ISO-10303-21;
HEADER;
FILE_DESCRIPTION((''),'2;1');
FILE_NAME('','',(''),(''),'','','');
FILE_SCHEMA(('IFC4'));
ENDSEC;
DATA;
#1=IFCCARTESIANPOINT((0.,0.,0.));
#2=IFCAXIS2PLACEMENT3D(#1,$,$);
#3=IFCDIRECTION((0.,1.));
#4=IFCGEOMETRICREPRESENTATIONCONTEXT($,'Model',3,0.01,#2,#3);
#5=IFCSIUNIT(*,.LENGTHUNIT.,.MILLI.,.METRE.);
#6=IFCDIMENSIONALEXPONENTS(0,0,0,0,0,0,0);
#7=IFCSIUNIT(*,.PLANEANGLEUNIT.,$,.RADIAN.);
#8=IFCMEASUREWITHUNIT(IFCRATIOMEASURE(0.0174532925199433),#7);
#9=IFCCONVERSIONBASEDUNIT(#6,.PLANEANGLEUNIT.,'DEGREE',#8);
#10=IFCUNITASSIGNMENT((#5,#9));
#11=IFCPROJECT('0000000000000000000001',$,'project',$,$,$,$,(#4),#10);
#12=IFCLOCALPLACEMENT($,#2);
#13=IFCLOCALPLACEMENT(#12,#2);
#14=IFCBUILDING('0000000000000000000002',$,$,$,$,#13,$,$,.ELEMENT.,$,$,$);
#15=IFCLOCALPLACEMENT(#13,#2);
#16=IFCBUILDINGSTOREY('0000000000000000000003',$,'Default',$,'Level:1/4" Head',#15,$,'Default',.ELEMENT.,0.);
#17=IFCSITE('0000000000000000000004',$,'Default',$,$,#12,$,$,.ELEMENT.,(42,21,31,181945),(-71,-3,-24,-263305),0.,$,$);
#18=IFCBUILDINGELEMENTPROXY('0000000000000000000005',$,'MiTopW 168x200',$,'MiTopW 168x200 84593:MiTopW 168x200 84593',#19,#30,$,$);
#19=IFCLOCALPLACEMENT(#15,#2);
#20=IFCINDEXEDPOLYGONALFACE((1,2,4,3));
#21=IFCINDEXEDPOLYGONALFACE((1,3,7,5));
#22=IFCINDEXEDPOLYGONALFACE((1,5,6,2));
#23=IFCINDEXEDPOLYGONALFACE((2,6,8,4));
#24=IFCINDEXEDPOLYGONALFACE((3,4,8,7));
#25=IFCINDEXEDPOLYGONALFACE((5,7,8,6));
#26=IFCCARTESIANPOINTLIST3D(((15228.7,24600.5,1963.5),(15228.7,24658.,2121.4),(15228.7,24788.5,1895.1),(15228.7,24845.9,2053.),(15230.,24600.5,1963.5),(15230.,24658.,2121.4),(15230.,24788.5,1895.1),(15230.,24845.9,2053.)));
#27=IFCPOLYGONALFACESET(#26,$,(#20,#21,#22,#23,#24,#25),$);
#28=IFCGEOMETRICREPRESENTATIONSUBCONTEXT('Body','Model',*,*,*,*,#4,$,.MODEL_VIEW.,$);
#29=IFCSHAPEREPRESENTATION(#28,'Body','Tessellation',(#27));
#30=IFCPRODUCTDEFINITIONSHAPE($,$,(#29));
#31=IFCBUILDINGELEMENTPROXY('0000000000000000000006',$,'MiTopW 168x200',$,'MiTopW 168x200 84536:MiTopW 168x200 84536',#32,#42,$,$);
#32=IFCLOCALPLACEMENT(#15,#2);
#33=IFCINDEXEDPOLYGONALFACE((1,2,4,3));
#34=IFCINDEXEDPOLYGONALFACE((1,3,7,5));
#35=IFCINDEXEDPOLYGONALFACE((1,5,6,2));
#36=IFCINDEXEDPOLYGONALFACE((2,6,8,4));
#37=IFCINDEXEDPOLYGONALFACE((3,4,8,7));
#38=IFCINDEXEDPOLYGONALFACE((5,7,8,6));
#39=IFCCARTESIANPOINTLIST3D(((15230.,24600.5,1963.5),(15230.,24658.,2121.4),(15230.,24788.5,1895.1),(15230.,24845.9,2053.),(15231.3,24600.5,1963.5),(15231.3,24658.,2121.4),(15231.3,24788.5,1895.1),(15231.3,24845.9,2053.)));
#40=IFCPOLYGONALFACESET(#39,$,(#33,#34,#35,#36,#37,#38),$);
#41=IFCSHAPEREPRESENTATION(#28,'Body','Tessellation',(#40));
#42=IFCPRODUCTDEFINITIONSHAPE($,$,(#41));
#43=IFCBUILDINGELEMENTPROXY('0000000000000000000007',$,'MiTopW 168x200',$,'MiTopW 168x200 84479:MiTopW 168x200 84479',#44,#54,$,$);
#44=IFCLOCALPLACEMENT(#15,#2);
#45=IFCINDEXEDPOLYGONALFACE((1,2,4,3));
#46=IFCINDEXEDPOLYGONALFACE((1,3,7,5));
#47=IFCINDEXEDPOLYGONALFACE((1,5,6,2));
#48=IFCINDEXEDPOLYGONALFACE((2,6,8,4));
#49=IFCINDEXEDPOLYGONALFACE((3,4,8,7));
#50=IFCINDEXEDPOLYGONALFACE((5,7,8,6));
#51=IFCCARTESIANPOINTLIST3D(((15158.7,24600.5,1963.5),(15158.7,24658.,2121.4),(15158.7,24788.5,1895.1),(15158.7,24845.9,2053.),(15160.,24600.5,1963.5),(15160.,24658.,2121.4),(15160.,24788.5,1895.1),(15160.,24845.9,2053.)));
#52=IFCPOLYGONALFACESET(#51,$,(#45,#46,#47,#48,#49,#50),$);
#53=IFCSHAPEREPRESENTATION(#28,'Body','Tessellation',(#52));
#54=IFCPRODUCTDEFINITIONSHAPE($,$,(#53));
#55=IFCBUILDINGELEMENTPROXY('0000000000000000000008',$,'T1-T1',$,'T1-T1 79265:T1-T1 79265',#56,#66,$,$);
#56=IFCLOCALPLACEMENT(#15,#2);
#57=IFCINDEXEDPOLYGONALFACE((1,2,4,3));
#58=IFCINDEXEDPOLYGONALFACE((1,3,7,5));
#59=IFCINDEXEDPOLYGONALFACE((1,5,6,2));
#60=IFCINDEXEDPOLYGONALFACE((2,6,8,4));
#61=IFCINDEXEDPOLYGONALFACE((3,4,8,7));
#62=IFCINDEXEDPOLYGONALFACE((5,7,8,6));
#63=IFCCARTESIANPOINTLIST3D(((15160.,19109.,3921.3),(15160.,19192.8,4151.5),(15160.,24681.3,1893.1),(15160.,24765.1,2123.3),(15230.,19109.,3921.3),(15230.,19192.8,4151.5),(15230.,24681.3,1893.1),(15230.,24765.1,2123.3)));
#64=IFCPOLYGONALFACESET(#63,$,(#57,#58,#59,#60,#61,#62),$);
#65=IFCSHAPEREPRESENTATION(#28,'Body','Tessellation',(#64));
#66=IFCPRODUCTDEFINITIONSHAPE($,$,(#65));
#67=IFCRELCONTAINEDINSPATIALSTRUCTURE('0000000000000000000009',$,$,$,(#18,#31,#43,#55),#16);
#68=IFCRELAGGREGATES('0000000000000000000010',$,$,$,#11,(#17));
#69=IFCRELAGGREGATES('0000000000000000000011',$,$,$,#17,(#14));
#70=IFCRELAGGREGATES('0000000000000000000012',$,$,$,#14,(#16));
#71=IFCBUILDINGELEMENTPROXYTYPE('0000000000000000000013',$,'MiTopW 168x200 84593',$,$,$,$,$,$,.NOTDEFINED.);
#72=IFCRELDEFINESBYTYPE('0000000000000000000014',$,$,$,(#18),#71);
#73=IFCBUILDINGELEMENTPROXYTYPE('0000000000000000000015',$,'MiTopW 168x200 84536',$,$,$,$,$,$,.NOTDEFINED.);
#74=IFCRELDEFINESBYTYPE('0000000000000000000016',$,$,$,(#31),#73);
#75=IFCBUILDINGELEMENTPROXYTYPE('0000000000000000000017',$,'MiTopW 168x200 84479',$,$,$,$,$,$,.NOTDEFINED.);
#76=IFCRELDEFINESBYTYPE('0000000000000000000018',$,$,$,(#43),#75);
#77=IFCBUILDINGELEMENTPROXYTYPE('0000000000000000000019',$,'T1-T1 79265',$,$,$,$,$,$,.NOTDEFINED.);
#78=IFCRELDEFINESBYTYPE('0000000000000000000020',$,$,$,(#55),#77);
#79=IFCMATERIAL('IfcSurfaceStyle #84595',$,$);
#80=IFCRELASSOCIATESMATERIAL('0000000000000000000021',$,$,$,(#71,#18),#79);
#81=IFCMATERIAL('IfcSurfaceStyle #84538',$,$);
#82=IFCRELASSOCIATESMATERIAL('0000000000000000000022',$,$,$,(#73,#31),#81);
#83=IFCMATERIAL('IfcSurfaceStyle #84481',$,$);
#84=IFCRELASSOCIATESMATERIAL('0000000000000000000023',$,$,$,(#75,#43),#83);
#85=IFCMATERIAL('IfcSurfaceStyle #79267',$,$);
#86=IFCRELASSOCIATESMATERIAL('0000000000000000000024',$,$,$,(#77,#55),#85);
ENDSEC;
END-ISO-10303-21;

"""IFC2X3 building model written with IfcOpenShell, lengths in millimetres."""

from ifc_helpers import new_model, entity, si_unit, converted_unit, direction, frame, origin, place, context, subcontext, project, spatial, polyline, outline, extrude, source, transform, mapped, material, type_object, type_shapes, element, save


model = new_model("IFC2X3")

# Units and contexts
model_context = context("Model", 3, precision=0.01, world=origin(), true_north=direction((0.0, 1.0)))
body_context = subcontext(model_context, "Body", "Model", "MODEL_VIEW")
ifc_project = project(units=[si_unit("LENGTHUNIT", "METRE", prefix="MILLI"), converted_unit("PLANEANGLEUNIT", "DEGREE", entity("IfcRatioMeasure", 0.0174532925199433), si_unit("PLANEANGLEUNIT", "RADIAN"), dimensions=[0, 0, 0, 0, 0, 0, 0])], contexts=[model_context])

# Site, building, storey
site_placement = place(None, origin())
site = spatial("IfcSite", under=ifc_project, at=site_placement, Name="Default", CompositionType="ELEMENT", RefLatitude=(42, 21, 31, 181945), RefLongitude=(-71, -3, -24, -263305), RefElevation=0.0)
building_placement = place(site_placement, origin())
building = spatial("IfcBuilding", under=site, at=building_placement, CompositionType="ELEMENT")
storey_placement = place(building_placement, origin())
storey = spatial("IfcBuildingStorey", under=building, at=storey_placement, Name="Default", ObjectType="Level:1/4\" Head", LongName="Default", CompositionType="ELEMENT", Elevation=0.0)

# Building element proxies
ifc_material_1 = material(Name="IfcSurfaceStyle #84595")
building_element_proxy_type_1 = type_object("IfcBuildingElementProxyType", Name="MiTopW 168x200 84593", PredefinedType="NOTDEFINED", material=ifc_material_1)
shared_shape_1 = source(origin(), body_context, "Body", "SweptSolid", [
    extrude(outline(polyline([(-100.0, -84.0), (100.0, -84.0), (100.0, 84.0), (-100.0, 84.0), (-100.0, -84.0)])), frame((100.0, 84.0, 0.0), z_axis=(0.0, 0.0, 1.0), x_axis=(-1.0, 0.0, 0.0)), (0.0, 0.0, 1.0), 1.3),
])
type_shapes(building_element_proxy_type_1, [shared_shape_1])
proxy_1_placement = place(building_placement, frame((15230.0, 24788.5, 1895.1), z_axis=(-1.0, 0.0, 0.0), x_axis=(0.0, -0.939693, 0.34202)))
element("IfcBuildingElementProxy", 1, at=proxy_1_placement, inside=storey, type_object=building_element_proxy_type_1, material=ifc_material_1, Name="MiTopW 168x200", ObjectType="MiTopW 168x200 84593:MiTopW 168x200 84593", context=body_context, shape_type="MappedRepresentation", body=[
    mapped(shared_shape_1, transform((0.0, 0.0, 0.0), scale=1.0)),
])
ifc_material_2 = material(Name="IfcSurfaceStyle #84538")
building_element_proxy_type_2 = type_object("IfcBuildingElementProxyType", Name="MiTopW 168x200 84536", PredefinedType="NOTDEFINED", material=ifc_material_2)
shared_shape_2 = source(origin(), body_context, "Body", "SweptSolid", [
    extrude(outline(polyline([(-100.0, -84.0), (100.0, -84.0), (100.0, 84.0), (-100.0, 84.0), (-100.0, -84.0)])), frame((100.0, 84.0, 0.0), z_axis=(0.0, 0.0, 1.0), x_axis=(-1.0, 0.0, 0.0)), (0.0, 0.0, 1.0), 1.3),
])
type_shapes(building_element_proxy_type_2, [shared_shape_2])
proxy_2_placement = place(building_placement, frame((15231.3, 24788.5, 1895.1), z_axis=(-1.0, 0.0, 0.0), x_axis=(0.0, -0.939693, 0.34202)))
element("IfcBuildingElementProxy", 2, at=proxy_2_placement, inside=storey, type_object=building_element_proxy_type_2, material=ifc_material_2, Name="MiTopW 168x200", ObjectType="MiTopW 168x200 84536:MiTopW 168x200 84536", context=body_context, shape_type="MappedRepresentation", body=[
    mapped(shared_shape_2, transform((0.0, 0.0, 0.0), scale=1.0)),
])
ifc_material_3 = material(Name="IfcSurfaceStyle #84481")
building_element_proxy_type_3 = type_object("IfcBuildingElementProxyType", Name="MiTopW 168x200 84479", PredefinedType="NOTDEFINED", material=ifc_material_3)
shared_shape_3 = source(origin(), body_context, "Body", "SweptSolid", [
    extrude(outline(polyline([(-100.0, -84.0), (100.0, -84.0), (100.0, 84.0), (-100.0, 84.0), (-100.0, -84.0)])), frame((100.0, 84.0, 0.0), z_axis=(0.0, 0.0, 1.0), x_axis=(-1.0, 0.0, 0.0)), (0.0, 0.0, 1.0), 1.3),
])
type_shapes(building_element_proxy_type_3, [shared_shape_3])
proxy_3_placement = place(building_placement, frame((15160.0, 24788.5, 1895.1), z_axis=(-1.0, 0.0, 0.0), x_axis=(0.0, -0.939693, 0.34202)))
element("IfcBuildingElementProxy", 3, at=proxy_3_placement, inside=storey, type_object=building_element_proxy_type_3, material=ifc_material_3, Name="MiTopW 168x200", ObjectType="MiTopW 168x200 84479:MiTopW 168x200 84479", context=body_context, shape_type="MappedRepresentation", body=[
    mapped(shared_shape_3, transform((0.0, 0.0, 0.0), scale=1.0)),
])
ifc_material_4 = material(Name="IfcSurfaceStyle #79267")
building_element_proxy_type_4 = type_object("IfcBuildingElementProxyType", Name="T1-T1 79265", PredefinedType="NOTDEFINED", material=ifc_material_4)
shared_shape_4 = source(origin(), body_context, "Body", "SweptSolid", [
    extrude(outline(polyline([(-2965.0, -122.5), (2965.0, -122.5), (2965.0, 122.5), (-2965.0, 122.5), (-2965.0, -122.5)])), frame((2965.0, 122.5, 0.0), z_axis=(0.0, 0.0, 1.0), x_axis=(-1.0, 0.0, 0.0)), (0.0, 0.0, 1.0), 70.0),
])
type_shapes(building_element_proxy_type_4, [shared_shape_4])
proxy_4_placement = place(building_placement, frame((15230.0, 24681.3, 1893.1), z_axis=(-1.0, 0.0, 0.0), x_axis=(0.0, -0.939693, 0.34202)))
element("IfcBuildingElementProxy", 4, at=proxy_4_placement, inside=storey, type_object=building_element_proxy_type_4, material=ifc_material_4, Name="T1-T1", ObjectType="T1-T1 79265:T1-T1 79265", context=body_context, shape_type="MappedRepresentation", body=[
    mapped(shared_shape_4, transform((0.0, 0.0, 0.0), scale=1.0)),
])

save(model, "model.ifc")
